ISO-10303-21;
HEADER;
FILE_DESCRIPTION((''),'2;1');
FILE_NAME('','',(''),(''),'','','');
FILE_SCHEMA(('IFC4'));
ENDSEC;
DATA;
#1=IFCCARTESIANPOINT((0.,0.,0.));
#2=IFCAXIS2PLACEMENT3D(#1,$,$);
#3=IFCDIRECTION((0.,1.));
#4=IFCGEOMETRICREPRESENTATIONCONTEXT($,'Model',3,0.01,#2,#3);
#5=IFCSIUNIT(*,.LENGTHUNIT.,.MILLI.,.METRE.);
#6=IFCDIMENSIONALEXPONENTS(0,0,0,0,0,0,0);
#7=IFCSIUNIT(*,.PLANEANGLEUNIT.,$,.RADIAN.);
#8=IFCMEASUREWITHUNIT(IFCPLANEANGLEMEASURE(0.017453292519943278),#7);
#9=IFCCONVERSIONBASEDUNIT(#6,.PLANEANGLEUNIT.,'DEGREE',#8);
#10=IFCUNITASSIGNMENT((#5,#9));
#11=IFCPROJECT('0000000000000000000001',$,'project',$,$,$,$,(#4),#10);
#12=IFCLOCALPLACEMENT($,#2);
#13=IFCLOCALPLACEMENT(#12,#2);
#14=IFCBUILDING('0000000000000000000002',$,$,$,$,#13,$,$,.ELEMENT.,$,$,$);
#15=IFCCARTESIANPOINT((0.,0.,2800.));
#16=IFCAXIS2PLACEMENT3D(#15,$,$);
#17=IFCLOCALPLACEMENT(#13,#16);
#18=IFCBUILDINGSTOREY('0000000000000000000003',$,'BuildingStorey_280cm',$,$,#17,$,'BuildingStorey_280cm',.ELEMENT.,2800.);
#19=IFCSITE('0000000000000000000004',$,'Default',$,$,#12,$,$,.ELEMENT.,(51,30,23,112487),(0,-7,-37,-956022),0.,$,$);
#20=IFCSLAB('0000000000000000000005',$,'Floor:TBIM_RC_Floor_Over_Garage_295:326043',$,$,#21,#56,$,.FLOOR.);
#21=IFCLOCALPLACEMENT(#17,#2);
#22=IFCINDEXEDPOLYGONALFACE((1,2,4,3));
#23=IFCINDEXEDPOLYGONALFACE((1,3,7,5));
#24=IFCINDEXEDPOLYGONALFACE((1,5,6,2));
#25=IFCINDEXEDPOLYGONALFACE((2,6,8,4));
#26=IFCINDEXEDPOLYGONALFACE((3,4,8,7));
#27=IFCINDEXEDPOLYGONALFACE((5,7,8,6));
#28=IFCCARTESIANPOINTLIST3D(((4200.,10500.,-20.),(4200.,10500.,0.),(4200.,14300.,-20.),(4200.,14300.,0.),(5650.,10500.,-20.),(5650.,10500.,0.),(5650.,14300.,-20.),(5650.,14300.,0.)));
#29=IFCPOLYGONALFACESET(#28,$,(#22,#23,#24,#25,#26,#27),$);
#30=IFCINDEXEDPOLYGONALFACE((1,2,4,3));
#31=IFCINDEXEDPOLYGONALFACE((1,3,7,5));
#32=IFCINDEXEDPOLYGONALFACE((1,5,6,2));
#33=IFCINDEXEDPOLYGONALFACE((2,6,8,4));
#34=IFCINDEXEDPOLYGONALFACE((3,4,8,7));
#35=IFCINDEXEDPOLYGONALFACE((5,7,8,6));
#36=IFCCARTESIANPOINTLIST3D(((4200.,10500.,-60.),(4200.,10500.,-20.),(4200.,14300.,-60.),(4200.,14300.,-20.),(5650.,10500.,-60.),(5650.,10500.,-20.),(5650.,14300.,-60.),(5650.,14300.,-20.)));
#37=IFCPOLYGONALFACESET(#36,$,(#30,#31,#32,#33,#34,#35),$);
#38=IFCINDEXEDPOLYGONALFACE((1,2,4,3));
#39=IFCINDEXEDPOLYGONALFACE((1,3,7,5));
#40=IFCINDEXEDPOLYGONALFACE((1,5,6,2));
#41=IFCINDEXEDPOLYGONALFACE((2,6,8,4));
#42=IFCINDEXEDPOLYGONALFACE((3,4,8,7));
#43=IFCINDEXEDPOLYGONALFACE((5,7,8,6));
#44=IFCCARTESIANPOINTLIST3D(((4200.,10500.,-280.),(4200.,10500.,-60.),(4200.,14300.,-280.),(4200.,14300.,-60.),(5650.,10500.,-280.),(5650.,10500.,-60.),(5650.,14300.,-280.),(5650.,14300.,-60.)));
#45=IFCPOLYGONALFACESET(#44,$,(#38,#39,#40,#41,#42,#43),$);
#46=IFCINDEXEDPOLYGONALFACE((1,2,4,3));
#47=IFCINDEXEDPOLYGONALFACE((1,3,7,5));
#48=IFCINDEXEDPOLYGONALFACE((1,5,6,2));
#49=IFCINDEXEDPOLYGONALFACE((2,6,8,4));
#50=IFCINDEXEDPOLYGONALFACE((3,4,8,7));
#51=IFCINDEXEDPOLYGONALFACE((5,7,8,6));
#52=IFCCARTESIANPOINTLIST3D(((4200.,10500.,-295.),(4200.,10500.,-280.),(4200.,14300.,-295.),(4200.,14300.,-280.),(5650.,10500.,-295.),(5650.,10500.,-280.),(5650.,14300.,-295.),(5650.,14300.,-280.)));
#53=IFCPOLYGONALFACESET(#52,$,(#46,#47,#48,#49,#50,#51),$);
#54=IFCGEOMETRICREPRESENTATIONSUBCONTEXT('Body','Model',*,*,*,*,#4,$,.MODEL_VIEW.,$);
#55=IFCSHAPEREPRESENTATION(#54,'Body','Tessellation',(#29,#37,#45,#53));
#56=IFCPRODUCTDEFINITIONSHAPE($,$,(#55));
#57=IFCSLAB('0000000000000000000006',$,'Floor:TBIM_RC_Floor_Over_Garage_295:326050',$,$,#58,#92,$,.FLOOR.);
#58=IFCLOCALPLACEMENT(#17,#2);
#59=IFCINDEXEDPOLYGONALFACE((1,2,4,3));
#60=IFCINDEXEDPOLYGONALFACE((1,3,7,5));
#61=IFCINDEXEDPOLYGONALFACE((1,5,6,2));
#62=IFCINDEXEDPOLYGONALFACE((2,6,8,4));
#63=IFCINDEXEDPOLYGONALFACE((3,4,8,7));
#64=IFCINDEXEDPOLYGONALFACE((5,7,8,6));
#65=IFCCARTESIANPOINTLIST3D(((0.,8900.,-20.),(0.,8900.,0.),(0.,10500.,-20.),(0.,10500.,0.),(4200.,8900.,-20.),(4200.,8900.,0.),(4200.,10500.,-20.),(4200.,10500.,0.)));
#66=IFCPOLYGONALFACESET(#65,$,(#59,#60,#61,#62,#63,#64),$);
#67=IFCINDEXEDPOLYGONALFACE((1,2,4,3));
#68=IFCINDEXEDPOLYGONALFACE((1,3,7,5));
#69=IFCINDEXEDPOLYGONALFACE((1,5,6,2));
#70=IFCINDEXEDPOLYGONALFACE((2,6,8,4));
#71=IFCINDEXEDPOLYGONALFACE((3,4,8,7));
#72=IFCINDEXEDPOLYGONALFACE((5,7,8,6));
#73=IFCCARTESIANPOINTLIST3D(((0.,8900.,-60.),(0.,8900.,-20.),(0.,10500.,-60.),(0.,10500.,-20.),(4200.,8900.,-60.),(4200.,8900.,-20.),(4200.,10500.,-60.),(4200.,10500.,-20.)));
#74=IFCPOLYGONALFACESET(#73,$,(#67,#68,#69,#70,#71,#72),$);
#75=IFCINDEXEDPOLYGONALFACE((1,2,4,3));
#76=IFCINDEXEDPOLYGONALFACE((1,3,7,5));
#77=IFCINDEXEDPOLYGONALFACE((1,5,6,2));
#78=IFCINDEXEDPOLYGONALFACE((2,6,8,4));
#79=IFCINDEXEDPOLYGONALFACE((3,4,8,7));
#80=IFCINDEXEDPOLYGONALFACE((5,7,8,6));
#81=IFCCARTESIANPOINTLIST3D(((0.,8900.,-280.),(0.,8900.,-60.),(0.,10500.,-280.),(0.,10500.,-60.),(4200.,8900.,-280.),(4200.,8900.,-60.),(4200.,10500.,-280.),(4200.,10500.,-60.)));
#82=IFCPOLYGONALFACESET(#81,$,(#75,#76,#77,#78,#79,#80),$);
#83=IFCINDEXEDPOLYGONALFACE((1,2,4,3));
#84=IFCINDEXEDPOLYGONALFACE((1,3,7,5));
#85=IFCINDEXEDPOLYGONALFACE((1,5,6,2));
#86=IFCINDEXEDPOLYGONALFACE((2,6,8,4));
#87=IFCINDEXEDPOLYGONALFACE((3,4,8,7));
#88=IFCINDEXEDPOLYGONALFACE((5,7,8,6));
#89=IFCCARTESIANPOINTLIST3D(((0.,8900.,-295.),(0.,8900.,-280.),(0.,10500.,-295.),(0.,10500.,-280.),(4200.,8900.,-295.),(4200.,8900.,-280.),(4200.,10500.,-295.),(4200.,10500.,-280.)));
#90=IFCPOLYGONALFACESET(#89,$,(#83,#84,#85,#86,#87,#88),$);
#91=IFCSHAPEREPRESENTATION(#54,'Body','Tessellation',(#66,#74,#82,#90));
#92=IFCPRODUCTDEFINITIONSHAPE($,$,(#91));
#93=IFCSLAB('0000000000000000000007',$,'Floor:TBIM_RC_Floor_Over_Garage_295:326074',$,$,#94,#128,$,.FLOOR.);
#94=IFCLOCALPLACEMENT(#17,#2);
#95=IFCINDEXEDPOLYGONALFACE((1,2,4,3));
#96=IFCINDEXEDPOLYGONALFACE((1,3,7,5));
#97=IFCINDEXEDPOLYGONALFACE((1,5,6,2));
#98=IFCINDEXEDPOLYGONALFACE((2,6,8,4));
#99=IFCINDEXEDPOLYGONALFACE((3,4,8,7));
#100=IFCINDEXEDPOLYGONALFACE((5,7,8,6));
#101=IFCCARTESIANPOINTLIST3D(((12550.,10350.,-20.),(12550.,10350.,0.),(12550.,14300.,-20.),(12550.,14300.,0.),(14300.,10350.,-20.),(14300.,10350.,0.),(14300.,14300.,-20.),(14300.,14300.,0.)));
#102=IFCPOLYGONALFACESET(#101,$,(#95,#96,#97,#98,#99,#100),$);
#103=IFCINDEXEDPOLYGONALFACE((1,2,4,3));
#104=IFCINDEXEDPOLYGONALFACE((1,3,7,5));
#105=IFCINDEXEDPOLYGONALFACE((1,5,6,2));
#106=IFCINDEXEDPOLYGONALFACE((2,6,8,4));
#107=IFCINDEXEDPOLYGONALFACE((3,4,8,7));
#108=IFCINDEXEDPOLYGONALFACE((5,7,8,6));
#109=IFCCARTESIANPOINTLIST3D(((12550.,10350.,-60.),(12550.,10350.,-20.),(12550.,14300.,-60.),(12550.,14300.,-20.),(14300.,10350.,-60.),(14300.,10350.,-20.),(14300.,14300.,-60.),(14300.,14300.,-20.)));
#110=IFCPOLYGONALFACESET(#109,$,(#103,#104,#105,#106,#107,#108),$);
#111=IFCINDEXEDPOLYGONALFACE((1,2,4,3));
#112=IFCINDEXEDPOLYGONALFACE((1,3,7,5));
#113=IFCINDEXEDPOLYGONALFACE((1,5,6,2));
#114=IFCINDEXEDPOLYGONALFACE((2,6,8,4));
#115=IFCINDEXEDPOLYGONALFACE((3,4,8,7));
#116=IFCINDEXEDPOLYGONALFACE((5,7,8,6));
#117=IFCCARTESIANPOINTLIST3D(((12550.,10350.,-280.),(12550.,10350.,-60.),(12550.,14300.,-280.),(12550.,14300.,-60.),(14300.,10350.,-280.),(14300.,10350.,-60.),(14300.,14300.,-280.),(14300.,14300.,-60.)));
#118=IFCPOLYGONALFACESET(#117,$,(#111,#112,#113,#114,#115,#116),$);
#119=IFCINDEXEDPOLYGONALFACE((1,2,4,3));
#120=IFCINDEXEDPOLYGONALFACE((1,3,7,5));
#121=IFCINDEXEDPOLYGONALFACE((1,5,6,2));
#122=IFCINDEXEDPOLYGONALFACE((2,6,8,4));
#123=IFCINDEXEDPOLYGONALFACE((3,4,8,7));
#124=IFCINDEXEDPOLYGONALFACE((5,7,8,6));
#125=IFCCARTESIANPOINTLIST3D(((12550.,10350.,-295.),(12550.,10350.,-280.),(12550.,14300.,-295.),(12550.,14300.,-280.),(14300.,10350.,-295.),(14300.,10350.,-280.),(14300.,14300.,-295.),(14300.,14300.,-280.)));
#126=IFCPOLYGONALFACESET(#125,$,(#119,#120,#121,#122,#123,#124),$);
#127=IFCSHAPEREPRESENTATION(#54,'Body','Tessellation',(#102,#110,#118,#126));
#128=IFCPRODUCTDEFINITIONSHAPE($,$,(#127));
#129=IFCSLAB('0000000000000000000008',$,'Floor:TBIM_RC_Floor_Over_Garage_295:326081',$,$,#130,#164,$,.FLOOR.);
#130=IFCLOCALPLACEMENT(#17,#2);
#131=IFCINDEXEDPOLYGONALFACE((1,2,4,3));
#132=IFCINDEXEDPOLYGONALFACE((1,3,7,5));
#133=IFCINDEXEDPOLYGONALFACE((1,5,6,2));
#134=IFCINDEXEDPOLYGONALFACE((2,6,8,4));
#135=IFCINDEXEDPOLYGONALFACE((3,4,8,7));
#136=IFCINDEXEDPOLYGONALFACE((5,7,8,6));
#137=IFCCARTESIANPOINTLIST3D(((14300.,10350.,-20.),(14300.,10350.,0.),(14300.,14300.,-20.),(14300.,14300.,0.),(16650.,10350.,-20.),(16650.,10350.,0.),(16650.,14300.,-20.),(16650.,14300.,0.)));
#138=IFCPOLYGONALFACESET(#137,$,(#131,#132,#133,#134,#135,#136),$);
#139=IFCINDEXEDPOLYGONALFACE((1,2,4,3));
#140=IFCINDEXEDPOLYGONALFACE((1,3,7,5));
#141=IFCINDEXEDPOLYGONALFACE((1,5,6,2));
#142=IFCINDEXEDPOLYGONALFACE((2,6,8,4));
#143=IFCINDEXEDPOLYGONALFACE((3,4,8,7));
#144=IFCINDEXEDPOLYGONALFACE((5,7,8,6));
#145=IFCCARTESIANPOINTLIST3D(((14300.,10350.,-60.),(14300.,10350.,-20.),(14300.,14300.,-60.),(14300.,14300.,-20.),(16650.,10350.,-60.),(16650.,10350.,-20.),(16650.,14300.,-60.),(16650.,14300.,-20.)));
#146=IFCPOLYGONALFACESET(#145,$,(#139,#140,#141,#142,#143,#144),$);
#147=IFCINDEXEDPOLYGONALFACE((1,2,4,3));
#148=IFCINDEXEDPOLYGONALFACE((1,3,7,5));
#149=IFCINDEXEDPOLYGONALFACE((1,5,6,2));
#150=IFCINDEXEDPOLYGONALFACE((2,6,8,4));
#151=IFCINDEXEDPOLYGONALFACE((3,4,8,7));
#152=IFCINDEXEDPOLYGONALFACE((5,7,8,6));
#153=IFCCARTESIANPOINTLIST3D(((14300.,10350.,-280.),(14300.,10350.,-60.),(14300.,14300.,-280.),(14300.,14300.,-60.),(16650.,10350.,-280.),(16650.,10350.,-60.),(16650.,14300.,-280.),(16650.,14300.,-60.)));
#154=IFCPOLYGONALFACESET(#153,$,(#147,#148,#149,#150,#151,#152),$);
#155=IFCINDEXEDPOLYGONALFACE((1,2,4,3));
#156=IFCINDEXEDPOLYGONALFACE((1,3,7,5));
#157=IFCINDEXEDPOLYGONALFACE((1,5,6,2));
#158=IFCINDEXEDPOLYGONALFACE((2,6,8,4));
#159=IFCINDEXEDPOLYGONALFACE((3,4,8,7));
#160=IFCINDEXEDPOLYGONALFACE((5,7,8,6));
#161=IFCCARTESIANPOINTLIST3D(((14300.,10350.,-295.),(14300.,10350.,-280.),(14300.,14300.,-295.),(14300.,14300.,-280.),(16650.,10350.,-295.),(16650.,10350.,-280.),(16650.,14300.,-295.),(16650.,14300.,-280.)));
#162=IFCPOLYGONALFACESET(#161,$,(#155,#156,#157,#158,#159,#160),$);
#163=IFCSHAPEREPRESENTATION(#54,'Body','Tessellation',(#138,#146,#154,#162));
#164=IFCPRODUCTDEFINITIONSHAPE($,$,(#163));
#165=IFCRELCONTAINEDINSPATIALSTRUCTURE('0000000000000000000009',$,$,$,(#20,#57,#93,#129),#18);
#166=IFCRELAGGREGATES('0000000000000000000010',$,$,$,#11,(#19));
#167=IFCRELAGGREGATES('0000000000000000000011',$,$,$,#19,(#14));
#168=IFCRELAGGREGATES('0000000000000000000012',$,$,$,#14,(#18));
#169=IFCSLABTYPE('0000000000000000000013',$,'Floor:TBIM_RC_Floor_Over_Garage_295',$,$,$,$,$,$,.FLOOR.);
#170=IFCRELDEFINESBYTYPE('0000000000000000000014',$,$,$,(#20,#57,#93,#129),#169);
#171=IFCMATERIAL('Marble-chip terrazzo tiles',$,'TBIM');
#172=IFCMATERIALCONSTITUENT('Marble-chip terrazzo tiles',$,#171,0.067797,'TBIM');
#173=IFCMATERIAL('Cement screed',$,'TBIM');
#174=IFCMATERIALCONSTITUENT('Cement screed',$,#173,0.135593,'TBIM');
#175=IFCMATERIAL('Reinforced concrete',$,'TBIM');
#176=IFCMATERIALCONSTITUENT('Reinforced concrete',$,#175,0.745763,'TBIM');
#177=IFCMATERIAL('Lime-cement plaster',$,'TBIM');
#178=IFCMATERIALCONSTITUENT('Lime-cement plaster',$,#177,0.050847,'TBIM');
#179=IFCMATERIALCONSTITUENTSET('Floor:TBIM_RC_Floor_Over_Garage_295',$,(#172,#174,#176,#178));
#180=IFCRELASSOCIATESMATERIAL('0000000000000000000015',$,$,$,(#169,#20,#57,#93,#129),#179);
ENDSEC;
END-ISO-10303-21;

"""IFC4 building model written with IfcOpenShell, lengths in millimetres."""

from ifc_helpers import new_model, entity, si_unit, converted_unit, direction, frame, origin, place, context, subcontext, project, spatial, indexed_curve, outline, extrude, material, constituent, constituent_set, type_object, element, save


model = new_model("IFC4")

# Units and contexts
model_context = context("Model", 3, precision=0.01, world=origin(), true_north=direction((0.0, 1.0)))
body_context = subcontext(model_context, "Body", "Model", "MODEL_VIEW")
ifc_project = project(units=[si_unit("LENGTHUNIT", "METRE", prefix="MILLI"), converted_unit("PLANEANGLEUNIT", "DEGREE", entity("IfcPlaneAngleMeasure", 0.017453292519943278), si_unit("PLANEANGLEUNIT", "RADIAN"), dimensions=[0, 0, 0, 0, 0, 0, 0])], contexts=[model_context])

# Site, building, storey
site_placement = place(None, origin())
site = spatial("IfcSite", under=ifc_project, at=site_placement, Name="Default", CompositionType="ELEMENT", RefLatitude=(51, 30, 23, 112487), RefLongitude=(0, -7, -37, -956022), RefElevation=0.0)
building_placement = place(site_placement, origin())
building = spatial("IfcBuilding", under=site, at=building_placement, CompositionType="ELEMENT")
storey_placement = place(building_placement, frame((0.0, 0.0, 2800.0)))
storey = spatial("IfcBuildingStorey", under=building, at=storey_placement, Name="BuildingStorey_280cm", LongName="BuildingStorey_280cm", CompositionType="ELEMENT", Elevation=2800.0)

# Slabs
ifc_material_1 = material(Name="Marble-chip terrazzo tiles", Category="TBIM")
ifc_constituent_1 = constituent(ifc_material_1, Name="Marble-chip terrazzo tiles", Category="TBIM", fraction=0.067797)
ifc_material_2 = material(Name="Cement screed", Category="TBIM")
ifc_constituent_2 = constituent(ifc_material_2, Name="Cement screed", Category="TBIM", fraction=0.135593)
ifc_material_3 = material(Name="Reinforced concrete", Category="TBIM")
ifc_constituent_3 = constituent(ifc_material_3, Name="Reinforced concrete", Category="TBIM", fraction=0.745763)
ifc_material_4 = material(Name="Lime-cement plaster", Category="TBIM")
ifc_constituent_4 = constituent(ifc_material_4, Name="Lime-cement plaster", Category="TBIM", fraction=0.050847)
ifc_constituent_set_1 = constituent_set(constituents=[ifc_constituent_1, ifc_constituent_2, ifc_constituent_3, ifc_constituent_4], Name="Floor:TBIM_RC_Floor_Over_Garage_295")
slab_type = type_object("IfcSlabType", Name="Floor:TBIM_RC_Floor_Over_Garage_295", PredefinedType="FLOOR", material=ifc_constituent_set_1)
slab_1_placement = place(storey_placement, origin())
element("IfcSlab", 1, at=slab_1_placement, inside=storey, type_object=slab_type, material=ifc_constituent_set_1, Name="Floor:TBIM_RC_Floor_Over_Garage_295:326043", PredefinedType="FLOOR", context=body_context, shape_type="SweptSolid", body=[
    extrude(outline(indexed_curve([(-725.0, -1900.0), (725.0, -1900.0), (725.0, 1900.0), (-725.0, 1900.0), (-725.0, -1900.0)], self_intersect=False)), frame((4925.0, 12400.0, -20.0), z_axis=(0.0, 0.0, 1.0), x_axis=(-1.0, 0.0, 0.0)), (0.0, 0.0, 1.0), 20.0),
    extrude(outline(indexed_curve([(-725.0, -1900.0), (725.0, -1900.0), (725.0, 1900.0), (-725.0, 1900.0), (-725.0, -1900.0)], self_intersect=False)), frame((4925.0, 12400.0, -60.0), z_axis=(0.0, 0.0, 1.0), x_axis=(-1.0, 0.0, 0.0)), (0.0, 0.0, 1.0), 40.0),
    extrude(outline(indexed_curve([(-725.0, -1900.0), (725.0, -1900.0), (725.0, 1900.0), (-725.0, 1900.0), (-725.0, -1900.0)], self_intersect=False)), frame((4925.0, 12400.0, -280.0), z_axis=(0.0, 0.0, 1.0), x_axis=(-1.0, 0.0, 0.0)), (0.0, 0.0, 1.0), 220.0),
    extrude(outline(indexed_curve([(-725.0, -1900.0), (725.0, -1900.0), (725.0, 1900.0), (-725.0, 1900.0), (-725.0, -1900.0)], self_intersect=False)), frame((4925.0, 12400.0, -295.0), z_axis=(0.0, 0.0, 1.0), x_axis=(-1.0, 0.0, 0.0)), (0.0, 0.0, 1.0), 15.0),
])
slab_2_placement = place(storey_placement, origin())
element("IfcSlab", 2, at=slab_2_placement, inside=storey, type_object=slab_type, material=ifc_constituent_set_1, Name="Floor:TBIM_RC_Floor_Over_Garage_295:326050", PredefinedType="FLOOR", context=body_context, shape_type="SweptSolid", body=[
    extrude(outline(indexed_curve([(-800.0, -2100.0), (800.0, -2100.0), (800.0, 2100.0), (-800.0, 2100.0), (-800.0, -2100.0)], self_intersect=False)), frame((2100.0, 9700.0, -20.0), z_axis=(0.0, 0.0, 1.0), x_axis=(0.0, -1.0, 0.0)), (0.0, 0.0, 1.0), 20.0),
    extrude(outline(indexed_curve([(-800.0, -2100.0), (800.0, -2100.0), (800.0, 2100.0), (-800.0, 2100.0), (-800.0, -2100.0)], self_intersect=False)), frame((2100.0, 9700.0, -60.0), z_axis=(0.0, 0.0, 1.0), x_axis=(0.0, -1.0, 0.0)), (0.0, 0.0, 1.0), 40.0),
    extrude(outline(indexed_curve([(-800.0, -2100.0), (800.0, -2100.0), (800.0, 2100.0), (-800.0, 2100.0), (-800.0, -2100.0)], self_intersect=False)), frame((2100.0, 9700.0, -280.0), z_axis=(0.0, 0.0, 1.0), x_axis=(0.0, -1.0, 0.0)), (0.0, 0.0, 1.0), 220.0),
    extrude(outline(indexed_curve([(-800.0, -2100.0), (800.0, -2100.0), (800.0, 2100.0), (-800.0, 2100.0), (-800.0, -2100.0)], self_intersect=False)), frame((2100.0, 9700.0, -295.0), z_axis=(0.0, 0.0, 1.0), x_axis=(0.0, -1.0, 0.0)), (0.0, 0.0, 1.0), 15.0),
])
slab_3_placement = place(storey_placement, origin())
element("IfcSlab", 3, at=slab_3_placement, inside=storey, type_object=slab_type, material=ifc_constituent_set_1, Name="Floor:TBIM_RC_Floor_Over_Garage_295:326074", PredefinedType="FLOOR", context=body_context, shape_type="SweptSolid", body=[
    extrude(outline(indexed_curve([(-875.0, -1975.0), (875.0, -1975.0), (875.0, 1975.0), (-875.0, 1975.0), (-875.0, -1975.0)], self_intersect=False)), frame((13425.0, 12325.0, -20.0), z_axis=(0.0, 0.0, 1.0), x_axis=(-1.0, 0.0, 0.0)), (0.0, 0.0, 1.0), 20.0),
    extrude(outline(indexed_curve([(-875.0, -1975.0), (875.0, -1975.0), (875.0, 1975.0), (-875.0, 1975.0), (-875.0, -1975.0)], self_intersect=False)), frame((13425.0, 12325.0, -60.0), z_axis=(0.0, 0.0, 1.0), x_axis=(-1.0, 0.0, 0.0)), (0.0, 0.0, 1.0), 40.0),
    extrude(outline(indexed_curve([(-875.0, -1975.0), (875.0, -1975.0), (875.0, 1975.0), (-875.0, 1975.0), (-875.0, -1975.0)], self_intersect=False)), frame((13425.0, 12325.0, -280.0), z_axis=(0.0, 0.0, 1.0), x_axis=(-1.0, 0.0, 0.0)), (0.0, 0.0, 1.0), 220.0),
    extrude(outline(indexed_curve([(-875.0, -1975.0), (875.0, -1975.0), (875.0, 1975.0), (-875.0, 1975.0), (-875.0, -1975.0)], self_intersect=False)), frame((13425.0, 12325.0, -295.0), z_axis=(0.0, 0.0, 1.0), x_axis=(-1.0, 0.0, 0.0)), (0.0, 0.0, 1.0), 15.0),
])
slab_4_placement = place(storey_placement, origin())
element("IfcSlab", 4, at=slab_4_placement, inside=storey, type_object=slab_type, material=ifc_constituent_set_1, Name="Floor:TBIM_RC_Floor_Over_Garage_295:326081", PredefinedType="FLOOR", context=body_context, shape_type="SweptSolid", body=[
    extrude(outline(indexed_curve([(-1175.0, -1975.0), (1175.0, -1975.0), (1175.0, 1975.0), (-1175.0, 1975.0), (-1175.0, -1975.0)], self_intersect=False)), frame((15475.0, 12325.0, -20.0), z_axis=(0.0, 0.0, 1.0), x_axis=(-1.0, 0.0, 0.0)), (0.0, 0.0, 1.0), 20.0),
    extrude(outline(indexed_curve([(-1175.0, -1975.0), (1175.0, -1975.0), (1175.0, 1975.0), (-1175.0, 1975.0), (-1175.0, -1975.0)], self_intersect=False)), frame((15475.0, 12325.0, -60.0), z_axis=(0.0, 0.0, 1.0), x_axis=(-1.0, 0.0, 0.0)), (0.0, 0.0, 1.0), 40.0),
    extrude(outline(indexed_curve([(-1175.0, -1975.0), (1175.0, -1975.0), (1175.0, 1975.0), (-1175.0, 1975.0), (-1175.0, -1975.0)], self_intersect=False)), frame((15475.0, 12325.0, -280.0), z_axis=(0.0, 0.0, 1.0), x_axis=(-1.0, 0.0, 0.0)), (0.0, 0.0, 1.0), 220.0),
    extrude(outline(indexed_curve([(-1175.0, -1975.0), (1175.0, -1975.0), (1175.0, 1975.0), (-1175.0, 1975.0), (-1175.0, -1975.0)], self_intersect=False)), frame((15475.0, 12325.0, -295.0), z_axis=(0.0, 0.0, 1.0), x_axis=(-1.0, 0.0, 0.0)), (0.0, 0.0, 1.0), 15.0),
])

save(model, "model.ifc")
